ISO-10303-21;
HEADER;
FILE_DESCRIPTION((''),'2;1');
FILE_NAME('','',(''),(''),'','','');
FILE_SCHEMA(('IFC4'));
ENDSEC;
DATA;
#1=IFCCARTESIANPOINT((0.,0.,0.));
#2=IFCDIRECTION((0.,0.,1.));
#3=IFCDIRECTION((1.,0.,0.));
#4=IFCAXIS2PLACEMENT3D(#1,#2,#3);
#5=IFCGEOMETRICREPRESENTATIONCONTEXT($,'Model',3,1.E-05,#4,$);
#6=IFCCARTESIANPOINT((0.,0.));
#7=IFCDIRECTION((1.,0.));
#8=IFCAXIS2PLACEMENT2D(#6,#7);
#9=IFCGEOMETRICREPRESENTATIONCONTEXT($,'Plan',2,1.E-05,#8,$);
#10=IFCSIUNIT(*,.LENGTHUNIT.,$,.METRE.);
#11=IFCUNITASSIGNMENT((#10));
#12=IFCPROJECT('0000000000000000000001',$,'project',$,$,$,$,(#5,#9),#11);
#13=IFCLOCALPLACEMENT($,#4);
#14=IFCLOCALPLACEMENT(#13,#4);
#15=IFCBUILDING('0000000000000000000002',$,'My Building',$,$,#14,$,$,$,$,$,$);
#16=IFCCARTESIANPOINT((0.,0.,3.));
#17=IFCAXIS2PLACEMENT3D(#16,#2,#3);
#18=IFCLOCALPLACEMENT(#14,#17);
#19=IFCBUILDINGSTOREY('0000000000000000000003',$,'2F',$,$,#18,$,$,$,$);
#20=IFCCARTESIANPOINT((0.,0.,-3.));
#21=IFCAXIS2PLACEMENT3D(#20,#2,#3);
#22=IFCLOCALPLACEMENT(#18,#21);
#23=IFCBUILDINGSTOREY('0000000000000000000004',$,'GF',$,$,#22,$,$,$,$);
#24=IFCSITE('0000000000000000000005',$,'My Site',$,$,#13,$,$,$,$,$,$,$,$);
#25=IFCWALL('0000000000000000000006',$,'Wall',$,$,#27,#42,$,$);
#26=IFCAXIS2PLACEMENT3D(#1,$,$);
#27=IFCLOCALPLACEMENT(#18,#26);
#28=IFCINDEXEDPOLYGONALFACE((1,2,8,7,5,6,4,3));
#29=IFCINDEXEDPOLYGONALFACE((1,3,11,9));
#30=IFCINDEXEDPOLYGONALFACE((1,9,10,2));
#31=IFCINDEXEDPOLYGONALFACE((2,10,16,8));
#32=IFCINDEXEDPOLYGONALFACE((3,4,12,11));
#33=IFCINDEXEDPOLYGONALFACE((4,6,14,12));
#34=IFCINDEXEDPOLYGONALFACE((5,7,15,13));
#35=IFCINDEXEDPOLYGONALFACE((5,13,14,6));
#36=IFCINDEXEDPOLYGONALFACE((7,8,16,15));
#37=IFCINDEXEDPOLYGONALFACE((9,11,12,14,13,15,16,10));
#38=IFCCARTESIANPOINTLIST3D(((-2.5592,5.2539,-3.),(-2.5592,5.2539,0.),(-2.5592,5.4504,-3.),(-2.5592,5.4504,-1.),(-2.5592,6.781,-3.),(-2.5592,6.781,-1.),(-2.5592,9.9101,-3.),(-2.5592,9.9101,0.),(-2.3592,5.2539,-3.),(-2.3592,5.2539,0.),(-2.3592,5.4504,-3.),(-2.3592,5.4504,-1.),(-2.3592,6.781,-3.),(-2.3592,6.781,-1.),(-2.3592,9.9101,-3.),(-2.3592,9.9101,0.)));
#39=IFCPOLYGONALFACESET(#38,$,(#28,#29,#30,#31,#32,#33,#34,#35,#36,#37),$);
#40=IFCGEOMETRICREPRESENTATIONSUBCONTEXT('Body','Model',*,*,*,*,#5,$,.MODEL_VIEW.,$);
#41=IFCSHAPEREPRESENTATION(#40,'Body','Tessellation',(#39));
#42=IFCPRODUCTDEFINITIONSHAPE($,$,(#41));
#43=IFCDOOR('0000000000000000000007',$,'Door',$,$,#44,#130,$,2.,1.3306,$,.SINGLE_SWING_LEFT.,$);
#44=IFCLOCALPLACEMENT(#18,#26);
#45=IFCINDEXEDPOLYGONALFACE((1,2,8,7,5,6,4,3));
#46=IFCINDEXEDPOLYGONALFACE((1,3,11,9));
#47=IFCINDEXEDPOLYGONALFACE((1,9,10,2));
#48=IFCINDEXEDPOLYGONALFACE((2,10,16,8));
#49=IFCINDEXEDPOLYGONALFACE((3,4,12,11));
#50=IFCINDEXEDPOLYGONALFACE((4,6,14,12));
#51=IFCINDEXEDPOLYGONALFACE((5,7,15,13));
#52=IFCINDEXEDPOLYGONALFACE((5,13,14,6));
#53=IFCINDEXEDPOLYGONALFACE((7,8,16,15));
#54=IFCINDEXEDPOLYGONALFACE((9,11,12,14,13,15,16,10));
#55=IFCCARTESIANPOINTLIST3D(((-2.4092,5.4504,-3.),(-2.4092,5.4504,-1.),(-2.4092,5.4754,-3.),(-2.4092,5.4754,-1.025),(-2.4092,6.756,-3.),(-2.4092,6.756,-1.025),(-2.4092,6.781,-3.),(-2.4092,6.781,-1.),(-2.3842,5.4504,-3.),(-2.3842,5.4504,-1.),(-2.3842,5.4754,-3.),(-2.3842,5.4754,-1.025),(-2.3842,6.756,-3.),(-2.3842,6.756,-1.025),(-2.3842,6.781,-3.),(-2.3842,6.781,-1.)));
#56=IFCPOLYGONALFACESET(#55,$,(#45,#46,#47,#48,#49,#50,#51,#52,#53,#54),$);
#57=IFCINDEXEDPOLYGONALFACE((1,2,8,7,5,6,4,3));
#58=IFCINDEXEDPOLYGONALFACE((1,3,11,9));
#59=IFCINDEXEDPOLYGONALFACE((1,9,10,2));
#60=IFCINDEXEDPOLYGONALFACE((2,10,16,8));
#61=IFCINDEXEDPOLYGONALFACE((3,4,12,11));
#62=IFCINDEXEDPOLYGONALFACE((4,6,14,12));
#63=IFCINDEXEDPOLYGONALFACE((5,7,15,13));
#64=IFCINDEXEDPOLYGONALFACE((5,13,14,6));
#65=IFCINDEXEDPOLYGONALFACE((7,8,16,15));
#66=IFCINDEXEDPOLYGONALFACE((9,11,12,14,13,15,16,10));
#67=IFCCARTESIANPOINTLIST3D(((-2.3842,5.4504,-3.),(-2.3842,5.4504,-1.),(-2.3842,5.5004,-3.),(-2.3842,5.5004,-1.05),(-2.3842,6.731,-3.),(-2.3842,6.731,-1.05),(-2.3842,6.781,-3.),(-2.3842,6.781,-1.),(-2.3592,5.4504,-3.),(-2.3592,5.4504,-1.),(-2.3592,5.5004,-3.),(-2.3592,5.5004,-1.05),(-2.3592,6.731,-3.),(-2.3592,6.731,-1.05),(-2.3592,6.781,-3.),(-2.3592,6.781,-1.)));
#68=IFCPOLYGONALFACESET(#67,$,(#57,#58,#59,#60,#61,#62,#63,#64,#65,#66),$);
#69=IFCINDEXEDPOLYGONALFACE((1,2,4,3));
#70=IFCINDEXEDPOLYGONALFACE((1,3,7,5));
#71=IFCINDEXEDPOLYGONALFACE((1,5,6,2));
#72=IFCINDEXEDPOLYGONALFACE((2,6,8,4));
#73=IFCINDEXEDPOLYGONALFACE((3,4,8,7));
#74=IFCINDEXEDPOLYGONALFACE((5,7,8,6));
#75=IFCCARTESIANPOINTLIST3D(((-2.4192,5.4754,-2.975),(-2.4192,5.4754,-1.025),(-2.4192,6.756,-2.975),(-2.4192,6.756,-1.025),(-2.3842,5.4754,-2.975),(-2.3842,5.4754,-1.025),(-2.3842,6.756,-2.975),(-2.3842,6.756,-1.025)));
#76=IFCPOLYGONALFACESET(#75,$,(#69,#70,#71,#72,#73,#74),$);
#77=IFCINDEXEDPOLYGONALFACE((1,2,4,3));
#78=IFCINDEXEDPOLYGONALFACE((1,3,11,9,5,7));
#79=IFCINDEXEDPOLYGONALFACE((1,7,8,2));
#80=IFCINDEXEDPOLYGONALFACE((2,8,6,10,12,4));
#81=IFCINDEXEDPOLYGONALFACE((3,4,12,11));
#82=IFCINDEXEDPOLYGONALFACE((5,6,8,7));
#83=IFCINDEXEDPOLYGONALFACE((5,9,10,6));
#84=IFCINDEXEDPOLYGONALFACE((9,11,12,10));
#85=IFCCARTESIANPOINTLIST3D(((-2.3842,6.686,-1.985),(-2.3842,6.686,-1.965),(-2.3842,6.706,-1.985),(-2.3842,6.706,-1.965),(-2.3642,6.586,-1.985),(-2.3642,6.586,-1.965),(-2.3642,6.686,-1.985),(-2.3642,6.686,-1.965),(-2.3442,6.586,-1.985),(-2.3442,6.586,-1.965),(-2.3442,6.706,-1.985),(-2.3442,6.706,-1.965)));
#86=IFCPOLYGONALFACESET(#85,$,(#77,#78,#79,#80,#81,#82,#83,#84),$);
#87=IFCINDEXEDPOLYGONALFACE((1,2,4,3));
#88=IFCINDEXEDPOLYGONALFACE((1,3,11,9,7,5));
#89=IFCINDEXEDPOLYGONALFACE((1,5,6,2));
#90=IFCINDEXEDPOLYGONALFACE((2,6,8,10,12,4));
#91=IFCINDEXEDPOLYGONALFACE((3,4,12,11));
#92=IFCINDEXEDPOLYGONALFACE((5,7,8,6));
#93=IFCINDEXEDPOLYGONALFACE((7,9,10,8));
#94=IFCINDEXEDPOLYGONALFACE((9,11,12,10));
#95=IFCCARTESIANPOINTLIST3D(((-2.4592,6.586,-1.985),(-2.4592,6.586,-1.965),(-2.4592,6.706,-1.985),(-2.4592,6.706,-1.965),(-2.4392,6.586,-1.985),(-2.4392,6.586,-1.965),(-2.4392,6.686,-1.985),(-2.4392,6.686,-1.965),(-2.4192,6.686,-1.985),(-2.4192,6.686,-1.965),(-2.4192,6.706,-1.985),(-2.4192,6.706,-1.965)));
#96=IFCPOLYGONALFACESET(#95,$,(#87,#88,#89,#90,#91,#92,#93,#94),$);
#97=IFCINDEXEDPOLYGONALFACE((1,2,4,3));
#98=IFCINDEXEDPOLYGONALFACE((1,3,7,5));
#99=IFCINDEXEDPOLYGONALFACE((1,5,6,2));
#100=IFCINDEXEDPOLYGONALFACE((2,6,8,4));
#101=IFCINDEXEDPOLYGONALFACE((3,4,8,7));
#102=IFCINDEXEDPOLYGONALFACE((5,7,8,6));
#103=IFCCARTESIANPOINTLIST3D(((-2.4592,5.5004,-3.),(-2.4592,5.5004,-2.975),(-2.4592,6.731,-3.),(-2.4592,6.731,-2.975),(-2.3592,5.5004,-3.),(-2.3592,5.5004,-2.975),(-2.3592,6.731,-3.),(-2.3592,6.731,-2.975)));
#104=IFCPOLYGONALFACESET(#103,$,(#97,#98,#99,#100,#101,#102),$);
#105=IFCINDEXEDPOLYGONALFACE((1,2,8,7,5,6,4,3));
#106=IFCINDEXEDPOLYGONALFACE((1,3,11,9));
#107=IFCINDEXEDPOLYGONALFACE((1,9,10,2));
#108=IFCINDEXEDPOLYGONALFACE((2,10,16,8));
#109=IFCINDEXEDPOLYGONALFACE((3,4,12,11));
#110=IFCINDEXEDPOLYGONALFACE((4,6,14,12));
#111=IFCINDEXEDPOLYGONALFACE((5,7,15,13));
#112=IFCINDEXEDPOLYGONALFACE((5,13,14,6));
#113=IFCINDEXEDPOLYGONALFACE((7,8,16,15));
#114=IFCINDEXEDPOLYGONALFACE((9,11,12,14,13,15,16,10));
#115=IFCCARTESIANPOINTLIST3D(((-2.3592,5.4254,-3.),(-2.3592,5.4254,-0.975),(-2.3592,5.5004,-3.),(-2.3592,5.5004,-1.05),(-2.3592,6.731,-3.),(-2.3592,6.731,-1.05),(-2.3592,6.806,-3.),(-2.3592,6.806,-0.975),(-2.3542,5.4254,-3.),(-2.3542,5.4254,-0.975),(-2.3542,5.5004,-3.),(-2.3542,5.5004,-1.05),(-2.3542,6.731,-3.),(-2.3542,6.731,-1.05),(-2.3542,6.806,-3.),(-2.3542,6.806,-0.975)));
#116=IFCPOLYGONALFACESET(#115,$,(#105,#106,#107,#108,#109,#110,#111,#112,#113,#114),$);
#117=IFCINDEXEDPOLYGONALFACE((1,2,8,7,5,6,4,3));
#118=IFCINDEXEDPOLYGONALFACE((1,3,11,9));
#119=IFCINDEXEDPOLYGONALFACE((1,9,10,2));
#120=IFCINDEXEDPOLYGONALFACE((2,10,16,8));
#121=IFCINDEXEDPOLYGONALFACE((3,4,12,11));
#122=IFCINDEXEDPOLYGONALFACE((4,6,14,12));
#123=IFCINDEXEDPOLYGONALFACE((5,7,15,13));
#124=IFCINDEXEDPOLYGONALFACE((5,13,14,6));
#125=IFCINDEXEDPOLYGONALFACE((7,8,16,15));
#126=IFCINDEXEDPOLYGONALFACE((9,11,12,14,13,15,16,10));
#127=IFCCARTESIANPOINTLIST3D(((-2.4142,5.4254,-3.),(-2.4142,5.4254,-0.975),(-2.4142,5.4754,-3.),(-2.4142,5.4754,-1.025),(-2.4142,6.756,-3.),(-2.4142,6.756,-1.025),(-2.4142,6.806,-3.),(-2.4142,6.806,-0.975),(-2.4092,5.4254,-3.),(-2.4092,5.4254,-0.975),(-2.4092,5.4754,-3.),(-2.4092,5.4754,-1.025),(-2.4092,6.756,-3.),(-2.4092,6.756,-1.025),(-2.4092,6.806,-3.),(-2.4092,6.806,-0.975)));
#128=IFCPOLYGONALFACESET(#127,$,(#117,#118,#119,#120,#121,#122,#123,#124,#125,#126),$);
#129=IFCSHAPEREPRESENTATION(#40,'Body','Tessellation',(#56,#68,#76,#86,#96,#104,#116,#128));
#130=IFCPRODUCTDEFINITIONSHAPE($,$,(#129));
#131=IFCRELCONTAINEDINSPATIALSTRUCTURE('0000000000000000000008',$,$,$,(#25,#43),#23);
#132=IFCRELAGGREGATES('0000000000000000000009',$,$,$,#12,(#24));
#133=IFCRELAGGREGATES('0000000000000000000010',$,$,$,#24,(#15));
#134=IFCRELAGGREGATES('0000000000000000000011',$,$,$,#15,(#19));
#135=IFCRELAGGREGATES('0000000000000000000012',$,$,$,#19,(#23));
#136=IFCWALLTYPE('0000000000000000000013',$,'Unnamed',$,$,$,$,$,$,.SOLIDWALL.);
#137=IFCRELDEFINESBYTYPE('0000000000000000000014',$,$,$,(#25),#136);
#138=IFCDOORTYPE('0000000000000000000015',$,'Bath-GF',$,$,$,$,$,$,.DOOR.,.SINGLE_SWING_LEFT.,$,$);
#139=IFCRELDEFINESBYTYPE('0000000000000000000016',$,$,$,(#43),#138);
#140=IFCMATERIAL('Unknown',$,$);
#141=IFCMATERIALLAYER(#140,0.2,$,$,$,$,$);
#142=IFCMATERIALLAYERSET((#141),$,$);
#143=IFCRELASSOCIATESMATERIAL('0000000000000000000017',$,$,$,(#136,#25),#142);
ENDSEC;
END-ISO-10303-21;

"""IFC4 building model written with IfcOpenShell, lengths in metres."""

from ifc_helpers import new_model, entity, si_unit, frame, origin_with_axes, origin_2d_with_axis, place, context, subcontext, project, spatial, line, indexed_curve, outline, extrude, shape, source, transform, mapped, material, layer, layer_set, layer_usage, type_object, type_shapes, element, fill, save


model = new_model("IFC4")

# Units and contexts
model_context = context("Model", 3, precision=1e-05, world=origin_with_axes())
plan_context = context("Plan", 2, precision=1e-05, world=origin_2d_with_axis())
body_context_1 = subcontext(model_context, "Body", "Model", "MODEL_VIEW")
body_context_2 = subcontext(plan_context, "Body", "Plan", "PLAN_VIEW")
ifc_project = project(units=[si_unit("LENGTHUNIT", "METRE")], contexts=[model_context, plan_context])

# Site, building, storeys
site_placement = place(None, origin_with_axes())
site = spatial("IfcSite", under=ifc_project, at=site_placement, Name="My Site")
building_placement = place(site_placement, origin_with_axes())
building = spatial("IfcBuilding", under=site, at=building_placement, Name="My Building")
storey_1_placement = place(building_placement, frame((0.0, 0.0, 3.0), z_axis=(0.0, 0.0, 1.0), x_axis=(1.0, 0.0, 0.0)))
storey_1 = spatial("IfcBuildingStorey", under=building, at=storey_1_placement, Name="2F")
storey_2_placement = place(storey_1_placement, frame((0.0, 0.0, -3.0), z_axis=(0.0, 0.0, 1.0), x_axis=(1.0, 0.0, 0.0)))
storey_2 = spatial("IfcBuildingStorey", under=storey_1, at=storey_2_placement, Name="GF")

# Shared definitions
ifc_material = material(Name="Unknown")

# Shared definitions
ifc_layer_1 = layer(ifc_material, 0.2)
ifc_layer_set_1 = layer_set([ifc_layer_1])
wall_type = type_object("IfcWallType", Name="Unnamed", PredefinedType="SOLIDWALL", material=ifc_layer_set_1)

# Wall, opening, door
ifc_layer_usage_1 = layer_usage(ifc_layer_set_1, "AXIS2", "POSITIVE", 0.0)
wall_1_placement = place(storey_2_placement, frame((-2.5592, 10.1101, 0.0), z_axis=(0.0, 0.0, 1.0), x_axis=(0.0, -1.0, 0.0)))
wall_1 = element("IfcWall", 1, at=wall_1_placement, inside=storey_2, type_object=wall_type, material=ifc_layer_usage_1, Name="Wall", context=body_context_1, shape_type="SweptSolid", body=[
    extrude(outline(indexed_curve([(0.2, 0.0), (0.2, 0.2), (4.8561, 0.2), (4.8561, 0.0)], segments=[line(1, 2, 3, 4, 1)])), origin_with_axes(), (0.0, 0.0, 1.0), 3.0),
])
shared_shape_1 = source(origin_with_axes(), body_context_1, "Body", "SweptSolid", [
    extrude(outline(indexed_curve([(0.0, 0.0), (1.3306, 0.0), (1.3306, 2.0), (0.0, 2.0)], segments=[line(1, 2, 3, 4, 1)])), frame((0.0, -0.6, 0.0), z_axis=(0.0, -1.0, 0.0), x_axis=(1.0, 0.0, 0.0)), (0.0, 0.0, -1.0), 1.2),
])
opening_1_placement = place(wall_1_placement, frame((4.6597, 0.2, 0.0), z_axis=(0.0, 0.0, 1.0), x_axis=(-1.0, 0.0, 0.0)))
opening_1 = element("IfcOpeningElement", 2, at=opening_1_placement, cuts=wall_1, PredefinedType="OPENING", context=body_context_1, shape_type="MappedRepresentation", body=[
    mapped(shared_shape_1, transform((0.0, 0.0, 0.0), x_axis=(1.0, 0.0, 0.0), y_axis=(0.0, 1.0, 0.0), z_axis=(0.0, 0.0, 1.0), scale=1.0)),
])
door_type_1 = type_object("IfcDoorType", Name="Bath-GF", OperationType="SINGLE_SWING_LEFT", PredefinedType="DOOR")
shared_shape_2 = source(origin_with_axes(), body_context_1, "Body", "SweptSolid", [
    extrude(outline(indexed_curve([(0.0, 0.0), (0.0, 2.0), (1.3306, 2.0), (1.3306, 0.0), (1.3056, 0.0), (1.3056, 1.975), (0.025, 1.975), (0.025, 0.0)], segments=[line(1, 2, 3, 4, 5, 6, 7, 8, 1)])), frame((0.0, 0.025, 0.0), z_axis=(0.0, -1.0, 0.0), x_axis=(1.0, 0.0, 0.0)), (0.0, 0.0, -1.0), 0.025),
    extrude(outline(indexed_curve([(0.0, 0.0), (0.0, 2.0), (1.3306, 2.0), (1.3306, 0.0), (1.2806, 0.0), (1.2806, 1.95), (0.05, 1.95), (0.05, 0.0)], segments=[line(1, 2, 3, 4, 5, 6, 7, 8, 1)])), frame((0.0, 0.0, 0.0), z_axis=(0.0, -1.0, 0.0), x_axis=(1.0, 0.0, 0.0)), (0.0, 0.0, -1.0), 0.025),
    extrude(outline(indexed_curve([(0.0, 0.0), (1.2806, 0.0), (1.2806, 0.035), (0.0, 0.035)], segments=[line(1, 2, 3, 4, 1)])), frame((0.025, 0.025, 0.025), z_axis=(0.0, 0.0, 1.0), x_axis=(1.0, 0.0, 0.0)), (0.0, 0.0, 1.0), 1.95),
    extrude(outline(indexed_curve([(0.0, 0.0), (0.0, -0.04), (-0.12, -0.04), (-0.12, -0.02), (-0.02, -0.02), (-0.02, 0.0)], segments=[line(1, 2, 3, 4, 5, 6, 1)])), frame((1.2556, 0.025, 1.015), z_axis=(0.0, 0.0, 1.0), x_axis=(1.0, 0.0, 0.0)), (0.0, 0.0, 1.0), 0.02),
    extrude(outline(indexed_curve([(0.0, 0.0), (0.0, 0.04), (-0.12, 0.04), (-0.12, 0.02), (-0.02, 0.02), (-0.02, 0.0)], segments=[line(1, 2, 3, 4, 5, 6, 1)])), frame((1.2556, 0.06, 1.015), z_axis=(0.0, 0.0, 1.0), x_axis=(1.0, 0.0, 0.0)), (0.0, 0.0, 1.0), 0.02),
    extrude(outline(indexed_curve([(0.0, 0.0), (1.2306, 0.0), (1.2306, 0.1), (0.0, 0.1)], segments=[line(1, 2, 3, 4, 1)])), frame((0.05, 0.0, 0.0), z_axis=(0.0, 0.0, 1.0), x_axis=(1.0, 0.0, 0.0)), (0.0, 0.0, 1.0), 0.025),
    extrude(outline(indexed_curve([(0.0, 0.0), (0.0, 2.025), (1.3806, 2.025), (1.3806, 0.0), (1.3056, 0.0), (1.3056, 1.95), (0.075, 1.95), (0.075, 0.0)], segments=[line(1, 2, 3, 4, 5, 6, 7, 8, 1)])), frame((-0.025, -0.005, 0.0), z_axis=(0.0, -1.0, 0.0), x_axis=(1.0, 0.0, 0.0)), (0.0, 0.0, -1.0), 0.005),
    extrude(outline(indexed_curve([(0.0, 0.0), (0.0, 2.025), (1.3806, 2.025), (1.3806, 0.0), (1.3306, 0.0), (1.3306, 1.975), (0.05, 1.975), (0.05, 0.0)], segments=[line(1, 2, 3, 4, 5, 6, 7, 8, 1)])), frame((-0.025, 0.05, 0.0), z_axis=(0.0, -1.0, 0.0), x_axis=(1.0, 0.0, 0.0)), (0.0, 0.0, -1.0), 0.005),
])
shared_shape_3 = source(origin_with_axes(), body_context_2, "Body", "Curve2D", [
    entity("IfcIndexedPolyCurve", entity("IfcCartesianPointList2D", [[0.0, 0.0], [0.0, 0.05], [0.025, 0.05], [0.025, 0.025], [0.05, 0.025], [0.05, 0.0]]), [entity("IfcLineIndex", [1, 2, 3, 4, 5, 6, 1])]),
    entity("IfcIndexedPolyCurve", entity("IfcCartesianPointList2D", [[1.3306, 0.0], [1.3306, 0.05], [1.3056, 0.05], [1.3056, 0.025], [1.2806, 0.025], [1.2806, 0.0]]), [entity("IfcLineIndex", [1, 2, 3, 4, 5, 6, 1])]),
    entity("IfcTrimmedCurve", entity("IfcEllipse", entity("IfcAxis2Placement2D", entity("IfcCartesianPoint", [0.06, 0.05]), entity("IfcDirection", [1.0, 0.0])), 1.2456, 1.2806), [entity("IfcCartesianPoint", [1.3056, 0.05])], [entity("IfcCartesianPoint", [0.06, 1.3306])], True, "CARTESIAN"),
    entity("IfcIndexedPolyCurve", entity("IfcCartesianPointList2D", [[0.025, 0.05], [0.06, 0.05], [0.06, 1.3306], [0.025, 1.3306]]), [entity("IfcLineIndex", [1, 2, 3, 4, 1])]),
])
type_shapes(door_type_1, [shared_shape_2, shared_shape_3])
door_1_placement = place(opening_1_placement, frame((0.0, 0.0, 0.0), z_axis=(0.0, 0.0, 1.0), x_axis=(1.0, 0.0, 0.0)))
door_1 = element("IfcDoor", 3, at=door_1_placement, inside=storey_2, type_object=door_type_1, Name="Door", OperationType="SINGLE_SWING_LEFT", OverallHeight=2.0, OverallWidth=1.3306, shapes=[
    shape(body_context_1, "Body", "MappedRepresentation", [mapped(shared_shape_2, transform((0.0, 0.0, 0.0), x_axis=(1.0, 0.0, 0.0), y_axis=(0.0, 1.0, 0.0), z_axis=(0.0, 0.0, 1.0), scale=1.0))]),
    shape(body_context_2, "Body", "MappedRepresentation", [mapped(shared_shape_3, transform((0.0, 0.0, 0.0), x_axis=(1.0, 0.0, 0.0), y_axis=(0.0, 1.0, 0.0), z_axis=(0.0, 0.0, 1.0), scale=1.0))]),
])
fill(opening_1, door_1)

save(model, "model.ifc")
